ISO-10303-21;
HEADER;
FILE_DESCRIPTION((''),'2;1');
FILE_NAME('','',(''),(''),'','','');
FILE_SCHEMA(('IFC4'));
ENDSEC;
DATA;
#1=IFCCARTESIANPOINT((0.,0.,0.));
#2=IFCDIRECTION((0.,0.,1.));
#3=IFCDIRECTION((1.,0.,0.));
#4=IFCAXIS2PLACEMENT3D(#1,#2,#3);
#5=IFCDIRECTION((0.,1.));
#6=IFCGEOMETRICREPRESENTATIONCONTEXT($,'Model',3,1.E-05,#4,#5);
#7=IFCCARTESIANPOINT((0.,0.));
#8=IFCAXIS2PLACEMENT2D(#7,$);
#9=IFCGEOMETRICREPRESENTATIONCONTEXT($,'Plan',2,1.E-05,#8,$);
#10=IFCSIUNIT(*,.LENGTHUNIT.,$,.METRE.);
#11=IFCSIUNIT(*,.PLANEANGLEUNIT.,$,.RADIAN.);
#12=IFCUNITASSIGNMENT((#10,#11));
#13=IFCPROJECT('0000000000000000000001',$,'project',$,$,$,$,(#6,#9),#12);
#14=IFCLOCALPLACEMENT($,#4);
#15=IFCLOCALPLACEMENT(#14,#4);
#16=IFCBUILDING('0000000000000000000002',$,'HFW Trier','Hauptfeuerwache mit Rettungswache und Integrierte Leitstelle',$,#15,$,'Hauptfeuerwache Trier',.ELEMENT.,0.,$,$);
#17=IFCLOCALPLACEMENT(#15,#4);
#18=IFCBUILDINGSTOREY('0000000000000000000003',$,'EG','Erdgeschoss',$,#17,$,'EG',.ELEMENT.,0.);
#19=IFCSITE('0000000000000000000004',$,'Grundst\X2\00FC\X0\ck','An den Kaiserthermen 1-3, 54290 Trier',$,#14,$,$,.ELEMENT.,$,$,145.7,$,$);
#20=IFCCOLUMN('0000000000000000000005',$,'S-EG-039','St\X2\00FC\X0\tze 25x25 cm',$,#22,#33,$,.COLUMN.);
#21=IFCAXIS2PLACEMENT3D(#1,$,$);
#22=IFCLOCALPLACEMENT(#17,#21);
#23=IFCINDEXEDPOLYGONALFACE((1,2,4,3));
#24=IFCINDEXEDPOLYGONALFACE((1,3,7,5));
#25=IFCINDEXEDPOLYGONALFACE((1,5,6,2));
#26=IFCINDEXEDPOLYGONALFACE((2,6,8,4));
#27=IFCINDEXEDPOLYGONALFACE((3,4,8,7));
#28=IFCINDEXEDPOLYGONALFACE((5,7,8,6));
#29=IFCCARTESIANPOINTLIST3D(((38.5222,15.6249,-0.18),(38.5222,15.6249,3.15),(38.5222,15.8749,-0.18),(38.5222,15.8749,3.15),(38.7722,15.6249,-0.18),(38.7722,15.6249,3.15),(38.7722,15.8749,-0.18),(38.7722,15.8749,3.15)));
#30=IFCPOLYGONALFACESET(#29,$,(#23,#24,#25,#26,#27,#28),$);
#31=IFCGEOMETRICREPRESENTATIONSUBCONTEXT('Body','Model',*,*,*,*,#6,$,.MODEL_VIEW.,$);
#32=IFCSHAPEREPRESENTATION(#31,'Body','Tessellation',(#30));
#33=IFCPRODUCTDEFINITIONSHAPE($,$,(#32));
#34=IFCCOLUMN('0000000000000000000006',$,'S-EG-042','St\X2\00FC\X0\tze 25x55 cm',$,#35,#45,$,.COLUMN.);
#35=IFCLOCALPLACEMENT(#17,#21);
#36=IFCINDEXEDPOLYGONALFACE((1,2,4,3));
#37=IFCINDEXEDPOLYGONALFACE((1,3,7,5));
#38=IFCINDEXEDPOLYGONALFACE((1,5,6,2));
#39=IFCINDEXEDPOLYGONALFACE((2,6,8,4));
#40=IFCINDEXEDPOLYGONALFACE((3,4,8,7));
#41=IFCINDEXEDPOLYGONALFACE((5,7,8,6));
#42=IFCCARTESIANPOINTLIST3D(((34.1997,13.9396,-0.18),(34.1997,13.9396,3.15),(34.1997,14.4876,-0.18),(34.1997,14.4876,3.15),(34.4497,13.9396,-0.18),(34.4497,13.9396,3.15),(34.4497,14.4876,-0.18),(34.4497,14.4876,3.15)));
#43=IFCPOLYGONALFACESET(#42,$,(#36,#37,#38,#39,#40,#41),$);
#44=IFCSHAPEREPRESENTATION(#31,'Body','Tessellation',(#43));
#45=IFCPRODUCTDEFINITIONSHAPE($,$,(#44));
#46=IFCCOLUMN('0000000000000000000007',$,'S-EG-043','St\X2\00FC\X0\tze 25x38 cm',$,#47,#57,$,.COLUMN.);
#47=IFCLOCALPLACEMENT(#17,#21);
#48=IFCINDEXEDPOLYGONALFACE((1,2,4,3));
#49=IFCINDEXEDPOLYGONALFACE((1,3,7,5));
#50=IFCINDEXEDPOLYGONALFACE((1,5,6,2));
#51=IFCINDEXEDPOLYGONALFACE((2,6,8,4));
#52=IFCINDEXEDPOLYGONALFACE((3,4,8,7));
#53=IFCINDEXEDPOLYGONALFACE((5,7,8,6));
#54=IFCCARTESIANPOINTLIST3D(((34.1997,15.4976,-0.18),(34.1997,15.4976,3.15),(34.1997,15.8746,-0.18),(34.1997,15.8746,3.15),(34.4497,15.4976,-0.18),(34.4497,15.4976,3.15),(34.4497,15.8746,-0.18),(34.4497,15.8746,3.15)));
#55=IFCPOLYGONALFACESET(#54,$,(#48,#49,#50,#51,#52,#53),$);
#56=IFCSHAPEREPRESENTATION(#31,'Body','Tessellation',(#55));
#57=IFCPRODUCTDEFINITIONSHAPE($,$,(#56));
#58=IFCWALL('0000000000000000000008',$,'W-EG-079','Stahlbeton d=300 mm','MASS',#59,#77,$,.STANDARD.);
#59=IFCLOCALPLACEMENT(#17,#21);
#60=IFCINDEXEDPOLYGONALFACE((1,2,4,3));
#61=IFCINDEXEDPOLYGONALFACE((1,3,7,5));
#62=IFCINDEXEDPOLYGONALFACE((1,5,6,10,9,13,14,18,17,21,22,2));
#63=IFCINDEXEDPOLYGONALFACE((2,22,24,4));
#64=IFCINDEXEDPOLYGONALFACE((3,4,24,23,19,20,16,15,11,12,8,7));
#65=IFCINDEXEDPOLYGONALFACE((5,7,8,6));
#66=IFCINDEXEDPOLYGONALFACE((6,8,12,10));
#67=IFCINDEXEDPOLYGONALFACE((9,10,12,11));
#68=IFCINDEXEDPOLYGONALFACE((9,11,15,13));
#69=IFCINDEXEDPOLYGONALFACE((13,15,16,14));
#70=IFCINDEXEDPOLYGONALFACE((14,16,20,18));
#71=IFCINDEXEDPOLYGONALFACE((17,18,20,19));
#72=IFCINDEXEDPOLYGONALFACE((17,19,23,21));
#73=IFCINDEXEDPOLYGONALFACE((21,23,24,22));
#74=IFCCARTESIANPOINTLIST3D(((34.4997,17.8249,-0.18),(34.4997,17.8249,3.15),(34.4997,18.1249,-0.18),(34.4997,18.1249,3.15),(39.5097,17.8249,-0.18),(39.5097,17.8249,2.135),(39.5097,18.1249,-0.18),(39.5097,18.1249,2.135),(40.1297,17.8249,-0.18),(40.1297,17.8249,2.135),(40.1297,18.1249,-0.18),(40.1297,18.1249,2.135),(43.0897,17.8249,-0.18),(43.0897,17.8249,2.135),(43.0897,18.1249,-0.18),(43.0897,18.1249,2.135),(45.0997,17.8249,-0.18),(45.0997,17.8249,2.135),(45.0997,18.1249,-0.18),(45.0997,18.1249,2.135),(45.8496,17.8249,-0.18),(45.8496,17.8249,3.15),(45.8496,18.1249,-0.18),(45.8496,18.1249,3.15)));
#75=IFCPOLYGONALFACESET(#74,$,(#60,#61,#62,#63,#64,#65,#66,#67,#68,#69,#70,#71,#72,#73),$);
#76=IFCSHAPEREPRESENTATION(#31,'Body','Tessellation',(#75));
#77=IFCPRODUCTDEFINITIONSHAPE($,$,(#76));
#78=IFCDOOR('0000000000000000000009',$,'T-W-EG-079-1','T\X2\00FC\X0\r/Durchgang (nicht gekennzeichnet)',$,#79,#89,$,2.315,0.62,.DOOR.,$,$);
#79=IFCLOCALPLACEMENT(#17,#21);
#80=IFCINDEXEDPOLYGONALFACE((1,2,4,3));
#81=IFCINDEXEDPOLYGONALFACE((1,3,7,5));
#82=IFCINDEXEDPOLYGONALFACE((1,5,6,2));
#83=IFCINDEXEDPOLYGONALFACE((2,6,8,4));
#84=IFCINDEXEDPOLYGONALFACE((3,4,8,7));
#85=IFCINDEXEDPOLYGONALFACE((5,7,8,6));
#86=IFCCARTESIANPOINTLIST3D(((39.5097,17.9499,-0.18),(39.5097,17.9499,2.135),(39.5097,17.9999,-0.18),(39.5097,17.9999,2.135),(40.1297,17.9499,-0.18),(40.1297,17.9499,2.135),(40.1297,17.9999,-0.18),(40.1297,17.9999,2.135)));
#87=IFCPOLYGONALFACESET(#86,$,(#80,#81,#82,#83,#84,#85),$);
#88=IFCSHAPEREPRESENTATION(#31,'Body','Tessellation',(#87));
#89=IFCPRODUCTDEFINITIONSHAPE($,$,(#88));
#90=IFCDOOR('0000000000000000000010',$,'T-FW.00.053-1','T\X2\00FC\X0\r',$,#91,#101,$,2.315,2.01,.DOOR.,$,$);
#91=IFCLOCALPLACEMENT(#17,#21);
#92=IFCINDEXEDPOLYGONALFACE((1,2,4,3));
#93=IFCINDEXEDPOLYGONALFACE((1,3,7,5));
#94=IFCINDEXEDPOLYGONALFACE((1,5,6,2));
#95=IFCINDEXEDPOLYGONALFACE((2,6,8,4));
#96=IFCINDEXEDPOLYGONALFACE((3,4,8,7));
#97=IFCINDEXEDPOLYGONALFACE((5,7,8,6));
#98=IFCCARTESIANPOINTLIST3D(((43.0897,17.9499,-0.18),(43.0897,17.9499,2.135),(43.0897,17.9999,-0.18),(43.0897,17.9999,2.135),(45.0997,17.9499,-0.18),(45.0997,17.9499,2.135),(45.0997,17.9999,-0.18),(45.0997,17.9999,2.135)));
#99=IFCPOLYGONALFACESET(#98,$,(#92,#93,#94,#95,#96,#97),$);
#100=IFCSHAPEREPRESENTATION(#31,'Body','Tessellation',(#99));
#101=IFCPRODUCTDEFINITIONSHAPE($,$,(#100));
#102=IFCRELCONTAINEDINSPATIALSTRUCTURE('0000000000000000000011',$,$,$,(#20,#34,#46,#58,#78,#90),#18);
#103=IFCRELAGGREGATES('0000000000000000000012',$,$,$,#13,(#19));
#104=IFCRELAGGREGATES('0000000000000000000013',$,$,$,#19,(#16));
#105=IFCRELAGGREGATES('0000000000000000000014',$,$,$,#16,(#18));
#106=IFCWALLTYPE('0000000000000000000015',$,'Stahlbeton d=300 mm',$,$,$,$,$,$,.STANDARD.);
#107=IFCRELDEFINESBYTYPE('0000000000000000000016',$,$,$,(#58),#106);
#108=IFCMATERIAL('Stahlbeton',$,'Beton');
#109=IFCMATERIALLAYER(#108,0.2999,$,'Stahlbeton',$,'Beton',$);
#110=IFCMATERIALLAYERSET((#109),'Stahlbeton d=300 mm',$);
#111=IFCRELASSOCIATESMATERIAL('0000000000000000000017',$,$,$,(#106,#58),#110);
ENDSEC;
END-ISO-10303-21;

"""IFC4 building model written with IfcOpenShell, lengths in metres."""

from ifc_helpers import new_model, si_unit, direction, frame, frame_2d, origin_with_axes, origin_2d, place, context, subcontext, project, spatial, rectangle, extrude, material, layer, layer_set, layer_usage, type_object, element, fill, save


model = new_model("IFC4")

# Units and contexts
model_context = context("Model", 3, precision=1e-05, world=origin_with_axes(), true_north=direction((0.0, 1.0)))
plan_context = context("Plan", 2, precision=1e-05, world=origin_2d())
body_context = subcontext(model_context, "Body", "Model", "MODEL_VIEW")
ifc_project = project(units=[si_unit("LENGTHUNIT", "METRE"), si_unit("PLANEANGLEUNIT", "RADIAN")], contexts=[model_context, plan_context])

# Site, building, storey
site_placement = place(None, origin_with_axes())
site = spatial("IfcSite", under=ifc_project, at=site_placement, Name="Grundstück", Description="An den Kaiserthermen 1-3, 54290 Trier", CompositionType="ELEMENT", RefElevation=145.7)
building_placement = place(site_placement, origin_with_axes())
building = spatial("IfcBuilding", under=site, at=building_placement, Name="HFW Trier", Description="Hauptfeuerwache mit Rettungswache und Integrierte Leitstelle", LongName="Hauptfeuerwache Trier", CompositionType="ELEMENT", ElevationOfRefHeight=0.0)
storey_placement = place(building_placement, origin_with_axes())
storey = spatial("IfcBuildingStorey", under=building, at=storey_placement, Name="EG", Description="Erdgeschoss", LongName="EG", CompositionType="ELEMENT", Elevation=0.0)

# Columns
column_1_placement = place(storey_placement, frame((38.5222, 15.7499, -0.18), z_axis=(0.0, 0.0, 1.0), x_axis=(1.0, 0.0, 0.0)))
element("IfcColumn", 1, at=column_1_placement, inside=storey, Name="S-EG-039", Description="Stütze 25x25 cm", PredefinedType="COLUMN", context=body_context, shape_type="SweptSolid", body=[
    extrude(rectangle(XDim=0.25, YDim=0.25, at=frame_2d((0.125, 0.0))), origin_with_axes(), (0.0, 0.0, 1.0), 3.33),
])
column_2_placement = place(storey_placement, frame((34.1997, 14.2136, -0.18), z_axis=(0.0, 0.0, 1.0), x_axis=(1.0, 0.0, 0.0)))
element("IfcColumn", 2, at=column_2_placement, inside=storey, Name="S-EG-042", Description="Stütze 25x55 cm", PredefinedType="COLUMN", context=body_context, shape_type="SweptSolid", body=[
    extrude(rectangle(XDim=0.25, YDim=0.548, at=frame_2d((0.125, 0.0))), origin_with_axes(), (0.0, 0.0, 1.0), 3.33),
])
column_3_placement = place(storey_placement, frame((34.1997, 15.6861, -0.18), z_axis=(0.0, 0.0, 1.0), x_axis=(1.0, 0.0, 0.0)))
element("IfcColumn", 3, at=column_3_placement, inside=storey, Name="S-EG-043", Description="Stütze 25x38 cm", PredefinedType="COLUMN", context=body_context, shape_type="SweptSolid", body=[
    extrude(rectangle(XDim=0.25, YDim=0.377, at=frame_2d((0.125, 0.0))), origin_with_axes(), (0.0, 0.0, 1.0), 3.33),
])

# Wall, openings, doors
ifc_material_1 = material(Name="Stahlbeton", Category="Beton")
ifc_layer_1 = layer(ifc_material_1, 0.2999, Name="Stahlbeton", Category="Beton")
ifc_layer_set_1 = layer_set([ifc_layer_1], Name="Stahlbeton d=300 mm")
ifc_layer_usage_1 = layer_usage(ifc_layer_set_1, "AXIS2", "POSITIVE", -0.15)
wall_type_1 = type_object("IfcWallType", Name="Stahlbeton d=300 mm", PredefinedType="STANDARD", material=ifc_layer_set_1)
wall_1_placement = place(storey_placement, frame((34.4997, 17.9749, -0.18), z_axis=(0.0, 0.0, 1.0), x_axis=(1.0, 0.0, 0.0)))
wall_1 = element("IfcWall", 4, at=wall_1_placement, inside=storey, type_object=wall_type_1, material=ifc_layer_usage_1, Name="W-EG-079", Description="Stahlbeton d=300 mm", ObjectType="MASS", PredefinedType="STANDARD", context=body_context, shape_type="SweptSolid", body=[
    extrude(rectangle(XDim=11.3499, YDim=0.3, at=frame_2d((5.675, 0.0))), origin_with_axes(), (0.0, 0.0, 1.0), 3.33),
])
opening_1_placement = place(wall_1_placement, frame((5.01, 0.0, 0.0), z_axis=(0.0, 0.0, 1.0), x_axis=(1.0, 0.0, 0.0)))
opening_1 = element("IfcOpeningElement", 5, at=opening_1_placement, cuts=wall_1, PredefinedType="OPENING", context=body_context, shape_type="SweptSolid", body=[
    extrude(rectangle(XDim=0.62, YDim=0.4, at=frame_2d((0.31, 0.0))), origin_with_axes(), (0.0, 0.0, 1.0), 2.315),
])
opening_2_placement = place(wall_1_placement, frame((8.59, 0.0, 0.0), z_axis=(0.0, 0.0, 1.0), x_axis=(1.0, 0.0, 0.0)))
opening_2 = element("IfcOpeningElement", 6, at=opening_2_placement, cuts=wall_1, PredefinedType="OPENING", context=body_context, shape_type="SweptSolid", body=[
    extrude(rectangle(XDim=2.01, YDim=0.4, at=frame_2d((1.005, 0.0))), origin_with_axes(), (0.0, 0.0, 1.0), 2.315),
])
door_1_placement = place(wall_1_placement, frame((5.01, 0.0, 0.0), z_axis=(0.0, 0.0, 1.0), x_axis=(1.0, 0.0, 0.0)))
door_1 = element("IfcDoor", 7, at=door_1_placement, inside=storey, Name="T-W-EG-079-1", Description="Tür/Durchgang (nicht gekennzeichnet)", OverallHeight=2.315, OverallWidth=0.62, PredefinedType="DOOR", context=body_context, shape_type="SweptSolid", body=[
    extrude(rectangle(XDim=0.62, YDim=0.05, at=frame_2d((0.31, 0.0))), origin_with_axes(), (0.0, 0.0, 1.0), 2.315),
])
fill(opening_1, door_1)
door_2_placement = place(wall_1_placement, frame((8.59, 0.0, 0.0), z_axis=(0.0, 0.0, 1.0), x_axis=(1.0, 0.0, 0.0)))
door_2 = element("IfcDoor", 8, at=door_2_placement, inside=storey, Name="T-FW.00.053-1", Description="Tür", OverallHeight=2.315, OverallWidth=2.01, PredefinedType="DOOR", context=body_context, shape_type="SweptSolid", body=[
    extrude(rectangle(XDim=2.01, YDim=0.05, at=frame_2d((1.005, 0.0))), origin_with_axes(), (0.0, 0.0, 1.0), 2.315),
])
fill(opening_2, door_2)

save(model, "model.ifc")
